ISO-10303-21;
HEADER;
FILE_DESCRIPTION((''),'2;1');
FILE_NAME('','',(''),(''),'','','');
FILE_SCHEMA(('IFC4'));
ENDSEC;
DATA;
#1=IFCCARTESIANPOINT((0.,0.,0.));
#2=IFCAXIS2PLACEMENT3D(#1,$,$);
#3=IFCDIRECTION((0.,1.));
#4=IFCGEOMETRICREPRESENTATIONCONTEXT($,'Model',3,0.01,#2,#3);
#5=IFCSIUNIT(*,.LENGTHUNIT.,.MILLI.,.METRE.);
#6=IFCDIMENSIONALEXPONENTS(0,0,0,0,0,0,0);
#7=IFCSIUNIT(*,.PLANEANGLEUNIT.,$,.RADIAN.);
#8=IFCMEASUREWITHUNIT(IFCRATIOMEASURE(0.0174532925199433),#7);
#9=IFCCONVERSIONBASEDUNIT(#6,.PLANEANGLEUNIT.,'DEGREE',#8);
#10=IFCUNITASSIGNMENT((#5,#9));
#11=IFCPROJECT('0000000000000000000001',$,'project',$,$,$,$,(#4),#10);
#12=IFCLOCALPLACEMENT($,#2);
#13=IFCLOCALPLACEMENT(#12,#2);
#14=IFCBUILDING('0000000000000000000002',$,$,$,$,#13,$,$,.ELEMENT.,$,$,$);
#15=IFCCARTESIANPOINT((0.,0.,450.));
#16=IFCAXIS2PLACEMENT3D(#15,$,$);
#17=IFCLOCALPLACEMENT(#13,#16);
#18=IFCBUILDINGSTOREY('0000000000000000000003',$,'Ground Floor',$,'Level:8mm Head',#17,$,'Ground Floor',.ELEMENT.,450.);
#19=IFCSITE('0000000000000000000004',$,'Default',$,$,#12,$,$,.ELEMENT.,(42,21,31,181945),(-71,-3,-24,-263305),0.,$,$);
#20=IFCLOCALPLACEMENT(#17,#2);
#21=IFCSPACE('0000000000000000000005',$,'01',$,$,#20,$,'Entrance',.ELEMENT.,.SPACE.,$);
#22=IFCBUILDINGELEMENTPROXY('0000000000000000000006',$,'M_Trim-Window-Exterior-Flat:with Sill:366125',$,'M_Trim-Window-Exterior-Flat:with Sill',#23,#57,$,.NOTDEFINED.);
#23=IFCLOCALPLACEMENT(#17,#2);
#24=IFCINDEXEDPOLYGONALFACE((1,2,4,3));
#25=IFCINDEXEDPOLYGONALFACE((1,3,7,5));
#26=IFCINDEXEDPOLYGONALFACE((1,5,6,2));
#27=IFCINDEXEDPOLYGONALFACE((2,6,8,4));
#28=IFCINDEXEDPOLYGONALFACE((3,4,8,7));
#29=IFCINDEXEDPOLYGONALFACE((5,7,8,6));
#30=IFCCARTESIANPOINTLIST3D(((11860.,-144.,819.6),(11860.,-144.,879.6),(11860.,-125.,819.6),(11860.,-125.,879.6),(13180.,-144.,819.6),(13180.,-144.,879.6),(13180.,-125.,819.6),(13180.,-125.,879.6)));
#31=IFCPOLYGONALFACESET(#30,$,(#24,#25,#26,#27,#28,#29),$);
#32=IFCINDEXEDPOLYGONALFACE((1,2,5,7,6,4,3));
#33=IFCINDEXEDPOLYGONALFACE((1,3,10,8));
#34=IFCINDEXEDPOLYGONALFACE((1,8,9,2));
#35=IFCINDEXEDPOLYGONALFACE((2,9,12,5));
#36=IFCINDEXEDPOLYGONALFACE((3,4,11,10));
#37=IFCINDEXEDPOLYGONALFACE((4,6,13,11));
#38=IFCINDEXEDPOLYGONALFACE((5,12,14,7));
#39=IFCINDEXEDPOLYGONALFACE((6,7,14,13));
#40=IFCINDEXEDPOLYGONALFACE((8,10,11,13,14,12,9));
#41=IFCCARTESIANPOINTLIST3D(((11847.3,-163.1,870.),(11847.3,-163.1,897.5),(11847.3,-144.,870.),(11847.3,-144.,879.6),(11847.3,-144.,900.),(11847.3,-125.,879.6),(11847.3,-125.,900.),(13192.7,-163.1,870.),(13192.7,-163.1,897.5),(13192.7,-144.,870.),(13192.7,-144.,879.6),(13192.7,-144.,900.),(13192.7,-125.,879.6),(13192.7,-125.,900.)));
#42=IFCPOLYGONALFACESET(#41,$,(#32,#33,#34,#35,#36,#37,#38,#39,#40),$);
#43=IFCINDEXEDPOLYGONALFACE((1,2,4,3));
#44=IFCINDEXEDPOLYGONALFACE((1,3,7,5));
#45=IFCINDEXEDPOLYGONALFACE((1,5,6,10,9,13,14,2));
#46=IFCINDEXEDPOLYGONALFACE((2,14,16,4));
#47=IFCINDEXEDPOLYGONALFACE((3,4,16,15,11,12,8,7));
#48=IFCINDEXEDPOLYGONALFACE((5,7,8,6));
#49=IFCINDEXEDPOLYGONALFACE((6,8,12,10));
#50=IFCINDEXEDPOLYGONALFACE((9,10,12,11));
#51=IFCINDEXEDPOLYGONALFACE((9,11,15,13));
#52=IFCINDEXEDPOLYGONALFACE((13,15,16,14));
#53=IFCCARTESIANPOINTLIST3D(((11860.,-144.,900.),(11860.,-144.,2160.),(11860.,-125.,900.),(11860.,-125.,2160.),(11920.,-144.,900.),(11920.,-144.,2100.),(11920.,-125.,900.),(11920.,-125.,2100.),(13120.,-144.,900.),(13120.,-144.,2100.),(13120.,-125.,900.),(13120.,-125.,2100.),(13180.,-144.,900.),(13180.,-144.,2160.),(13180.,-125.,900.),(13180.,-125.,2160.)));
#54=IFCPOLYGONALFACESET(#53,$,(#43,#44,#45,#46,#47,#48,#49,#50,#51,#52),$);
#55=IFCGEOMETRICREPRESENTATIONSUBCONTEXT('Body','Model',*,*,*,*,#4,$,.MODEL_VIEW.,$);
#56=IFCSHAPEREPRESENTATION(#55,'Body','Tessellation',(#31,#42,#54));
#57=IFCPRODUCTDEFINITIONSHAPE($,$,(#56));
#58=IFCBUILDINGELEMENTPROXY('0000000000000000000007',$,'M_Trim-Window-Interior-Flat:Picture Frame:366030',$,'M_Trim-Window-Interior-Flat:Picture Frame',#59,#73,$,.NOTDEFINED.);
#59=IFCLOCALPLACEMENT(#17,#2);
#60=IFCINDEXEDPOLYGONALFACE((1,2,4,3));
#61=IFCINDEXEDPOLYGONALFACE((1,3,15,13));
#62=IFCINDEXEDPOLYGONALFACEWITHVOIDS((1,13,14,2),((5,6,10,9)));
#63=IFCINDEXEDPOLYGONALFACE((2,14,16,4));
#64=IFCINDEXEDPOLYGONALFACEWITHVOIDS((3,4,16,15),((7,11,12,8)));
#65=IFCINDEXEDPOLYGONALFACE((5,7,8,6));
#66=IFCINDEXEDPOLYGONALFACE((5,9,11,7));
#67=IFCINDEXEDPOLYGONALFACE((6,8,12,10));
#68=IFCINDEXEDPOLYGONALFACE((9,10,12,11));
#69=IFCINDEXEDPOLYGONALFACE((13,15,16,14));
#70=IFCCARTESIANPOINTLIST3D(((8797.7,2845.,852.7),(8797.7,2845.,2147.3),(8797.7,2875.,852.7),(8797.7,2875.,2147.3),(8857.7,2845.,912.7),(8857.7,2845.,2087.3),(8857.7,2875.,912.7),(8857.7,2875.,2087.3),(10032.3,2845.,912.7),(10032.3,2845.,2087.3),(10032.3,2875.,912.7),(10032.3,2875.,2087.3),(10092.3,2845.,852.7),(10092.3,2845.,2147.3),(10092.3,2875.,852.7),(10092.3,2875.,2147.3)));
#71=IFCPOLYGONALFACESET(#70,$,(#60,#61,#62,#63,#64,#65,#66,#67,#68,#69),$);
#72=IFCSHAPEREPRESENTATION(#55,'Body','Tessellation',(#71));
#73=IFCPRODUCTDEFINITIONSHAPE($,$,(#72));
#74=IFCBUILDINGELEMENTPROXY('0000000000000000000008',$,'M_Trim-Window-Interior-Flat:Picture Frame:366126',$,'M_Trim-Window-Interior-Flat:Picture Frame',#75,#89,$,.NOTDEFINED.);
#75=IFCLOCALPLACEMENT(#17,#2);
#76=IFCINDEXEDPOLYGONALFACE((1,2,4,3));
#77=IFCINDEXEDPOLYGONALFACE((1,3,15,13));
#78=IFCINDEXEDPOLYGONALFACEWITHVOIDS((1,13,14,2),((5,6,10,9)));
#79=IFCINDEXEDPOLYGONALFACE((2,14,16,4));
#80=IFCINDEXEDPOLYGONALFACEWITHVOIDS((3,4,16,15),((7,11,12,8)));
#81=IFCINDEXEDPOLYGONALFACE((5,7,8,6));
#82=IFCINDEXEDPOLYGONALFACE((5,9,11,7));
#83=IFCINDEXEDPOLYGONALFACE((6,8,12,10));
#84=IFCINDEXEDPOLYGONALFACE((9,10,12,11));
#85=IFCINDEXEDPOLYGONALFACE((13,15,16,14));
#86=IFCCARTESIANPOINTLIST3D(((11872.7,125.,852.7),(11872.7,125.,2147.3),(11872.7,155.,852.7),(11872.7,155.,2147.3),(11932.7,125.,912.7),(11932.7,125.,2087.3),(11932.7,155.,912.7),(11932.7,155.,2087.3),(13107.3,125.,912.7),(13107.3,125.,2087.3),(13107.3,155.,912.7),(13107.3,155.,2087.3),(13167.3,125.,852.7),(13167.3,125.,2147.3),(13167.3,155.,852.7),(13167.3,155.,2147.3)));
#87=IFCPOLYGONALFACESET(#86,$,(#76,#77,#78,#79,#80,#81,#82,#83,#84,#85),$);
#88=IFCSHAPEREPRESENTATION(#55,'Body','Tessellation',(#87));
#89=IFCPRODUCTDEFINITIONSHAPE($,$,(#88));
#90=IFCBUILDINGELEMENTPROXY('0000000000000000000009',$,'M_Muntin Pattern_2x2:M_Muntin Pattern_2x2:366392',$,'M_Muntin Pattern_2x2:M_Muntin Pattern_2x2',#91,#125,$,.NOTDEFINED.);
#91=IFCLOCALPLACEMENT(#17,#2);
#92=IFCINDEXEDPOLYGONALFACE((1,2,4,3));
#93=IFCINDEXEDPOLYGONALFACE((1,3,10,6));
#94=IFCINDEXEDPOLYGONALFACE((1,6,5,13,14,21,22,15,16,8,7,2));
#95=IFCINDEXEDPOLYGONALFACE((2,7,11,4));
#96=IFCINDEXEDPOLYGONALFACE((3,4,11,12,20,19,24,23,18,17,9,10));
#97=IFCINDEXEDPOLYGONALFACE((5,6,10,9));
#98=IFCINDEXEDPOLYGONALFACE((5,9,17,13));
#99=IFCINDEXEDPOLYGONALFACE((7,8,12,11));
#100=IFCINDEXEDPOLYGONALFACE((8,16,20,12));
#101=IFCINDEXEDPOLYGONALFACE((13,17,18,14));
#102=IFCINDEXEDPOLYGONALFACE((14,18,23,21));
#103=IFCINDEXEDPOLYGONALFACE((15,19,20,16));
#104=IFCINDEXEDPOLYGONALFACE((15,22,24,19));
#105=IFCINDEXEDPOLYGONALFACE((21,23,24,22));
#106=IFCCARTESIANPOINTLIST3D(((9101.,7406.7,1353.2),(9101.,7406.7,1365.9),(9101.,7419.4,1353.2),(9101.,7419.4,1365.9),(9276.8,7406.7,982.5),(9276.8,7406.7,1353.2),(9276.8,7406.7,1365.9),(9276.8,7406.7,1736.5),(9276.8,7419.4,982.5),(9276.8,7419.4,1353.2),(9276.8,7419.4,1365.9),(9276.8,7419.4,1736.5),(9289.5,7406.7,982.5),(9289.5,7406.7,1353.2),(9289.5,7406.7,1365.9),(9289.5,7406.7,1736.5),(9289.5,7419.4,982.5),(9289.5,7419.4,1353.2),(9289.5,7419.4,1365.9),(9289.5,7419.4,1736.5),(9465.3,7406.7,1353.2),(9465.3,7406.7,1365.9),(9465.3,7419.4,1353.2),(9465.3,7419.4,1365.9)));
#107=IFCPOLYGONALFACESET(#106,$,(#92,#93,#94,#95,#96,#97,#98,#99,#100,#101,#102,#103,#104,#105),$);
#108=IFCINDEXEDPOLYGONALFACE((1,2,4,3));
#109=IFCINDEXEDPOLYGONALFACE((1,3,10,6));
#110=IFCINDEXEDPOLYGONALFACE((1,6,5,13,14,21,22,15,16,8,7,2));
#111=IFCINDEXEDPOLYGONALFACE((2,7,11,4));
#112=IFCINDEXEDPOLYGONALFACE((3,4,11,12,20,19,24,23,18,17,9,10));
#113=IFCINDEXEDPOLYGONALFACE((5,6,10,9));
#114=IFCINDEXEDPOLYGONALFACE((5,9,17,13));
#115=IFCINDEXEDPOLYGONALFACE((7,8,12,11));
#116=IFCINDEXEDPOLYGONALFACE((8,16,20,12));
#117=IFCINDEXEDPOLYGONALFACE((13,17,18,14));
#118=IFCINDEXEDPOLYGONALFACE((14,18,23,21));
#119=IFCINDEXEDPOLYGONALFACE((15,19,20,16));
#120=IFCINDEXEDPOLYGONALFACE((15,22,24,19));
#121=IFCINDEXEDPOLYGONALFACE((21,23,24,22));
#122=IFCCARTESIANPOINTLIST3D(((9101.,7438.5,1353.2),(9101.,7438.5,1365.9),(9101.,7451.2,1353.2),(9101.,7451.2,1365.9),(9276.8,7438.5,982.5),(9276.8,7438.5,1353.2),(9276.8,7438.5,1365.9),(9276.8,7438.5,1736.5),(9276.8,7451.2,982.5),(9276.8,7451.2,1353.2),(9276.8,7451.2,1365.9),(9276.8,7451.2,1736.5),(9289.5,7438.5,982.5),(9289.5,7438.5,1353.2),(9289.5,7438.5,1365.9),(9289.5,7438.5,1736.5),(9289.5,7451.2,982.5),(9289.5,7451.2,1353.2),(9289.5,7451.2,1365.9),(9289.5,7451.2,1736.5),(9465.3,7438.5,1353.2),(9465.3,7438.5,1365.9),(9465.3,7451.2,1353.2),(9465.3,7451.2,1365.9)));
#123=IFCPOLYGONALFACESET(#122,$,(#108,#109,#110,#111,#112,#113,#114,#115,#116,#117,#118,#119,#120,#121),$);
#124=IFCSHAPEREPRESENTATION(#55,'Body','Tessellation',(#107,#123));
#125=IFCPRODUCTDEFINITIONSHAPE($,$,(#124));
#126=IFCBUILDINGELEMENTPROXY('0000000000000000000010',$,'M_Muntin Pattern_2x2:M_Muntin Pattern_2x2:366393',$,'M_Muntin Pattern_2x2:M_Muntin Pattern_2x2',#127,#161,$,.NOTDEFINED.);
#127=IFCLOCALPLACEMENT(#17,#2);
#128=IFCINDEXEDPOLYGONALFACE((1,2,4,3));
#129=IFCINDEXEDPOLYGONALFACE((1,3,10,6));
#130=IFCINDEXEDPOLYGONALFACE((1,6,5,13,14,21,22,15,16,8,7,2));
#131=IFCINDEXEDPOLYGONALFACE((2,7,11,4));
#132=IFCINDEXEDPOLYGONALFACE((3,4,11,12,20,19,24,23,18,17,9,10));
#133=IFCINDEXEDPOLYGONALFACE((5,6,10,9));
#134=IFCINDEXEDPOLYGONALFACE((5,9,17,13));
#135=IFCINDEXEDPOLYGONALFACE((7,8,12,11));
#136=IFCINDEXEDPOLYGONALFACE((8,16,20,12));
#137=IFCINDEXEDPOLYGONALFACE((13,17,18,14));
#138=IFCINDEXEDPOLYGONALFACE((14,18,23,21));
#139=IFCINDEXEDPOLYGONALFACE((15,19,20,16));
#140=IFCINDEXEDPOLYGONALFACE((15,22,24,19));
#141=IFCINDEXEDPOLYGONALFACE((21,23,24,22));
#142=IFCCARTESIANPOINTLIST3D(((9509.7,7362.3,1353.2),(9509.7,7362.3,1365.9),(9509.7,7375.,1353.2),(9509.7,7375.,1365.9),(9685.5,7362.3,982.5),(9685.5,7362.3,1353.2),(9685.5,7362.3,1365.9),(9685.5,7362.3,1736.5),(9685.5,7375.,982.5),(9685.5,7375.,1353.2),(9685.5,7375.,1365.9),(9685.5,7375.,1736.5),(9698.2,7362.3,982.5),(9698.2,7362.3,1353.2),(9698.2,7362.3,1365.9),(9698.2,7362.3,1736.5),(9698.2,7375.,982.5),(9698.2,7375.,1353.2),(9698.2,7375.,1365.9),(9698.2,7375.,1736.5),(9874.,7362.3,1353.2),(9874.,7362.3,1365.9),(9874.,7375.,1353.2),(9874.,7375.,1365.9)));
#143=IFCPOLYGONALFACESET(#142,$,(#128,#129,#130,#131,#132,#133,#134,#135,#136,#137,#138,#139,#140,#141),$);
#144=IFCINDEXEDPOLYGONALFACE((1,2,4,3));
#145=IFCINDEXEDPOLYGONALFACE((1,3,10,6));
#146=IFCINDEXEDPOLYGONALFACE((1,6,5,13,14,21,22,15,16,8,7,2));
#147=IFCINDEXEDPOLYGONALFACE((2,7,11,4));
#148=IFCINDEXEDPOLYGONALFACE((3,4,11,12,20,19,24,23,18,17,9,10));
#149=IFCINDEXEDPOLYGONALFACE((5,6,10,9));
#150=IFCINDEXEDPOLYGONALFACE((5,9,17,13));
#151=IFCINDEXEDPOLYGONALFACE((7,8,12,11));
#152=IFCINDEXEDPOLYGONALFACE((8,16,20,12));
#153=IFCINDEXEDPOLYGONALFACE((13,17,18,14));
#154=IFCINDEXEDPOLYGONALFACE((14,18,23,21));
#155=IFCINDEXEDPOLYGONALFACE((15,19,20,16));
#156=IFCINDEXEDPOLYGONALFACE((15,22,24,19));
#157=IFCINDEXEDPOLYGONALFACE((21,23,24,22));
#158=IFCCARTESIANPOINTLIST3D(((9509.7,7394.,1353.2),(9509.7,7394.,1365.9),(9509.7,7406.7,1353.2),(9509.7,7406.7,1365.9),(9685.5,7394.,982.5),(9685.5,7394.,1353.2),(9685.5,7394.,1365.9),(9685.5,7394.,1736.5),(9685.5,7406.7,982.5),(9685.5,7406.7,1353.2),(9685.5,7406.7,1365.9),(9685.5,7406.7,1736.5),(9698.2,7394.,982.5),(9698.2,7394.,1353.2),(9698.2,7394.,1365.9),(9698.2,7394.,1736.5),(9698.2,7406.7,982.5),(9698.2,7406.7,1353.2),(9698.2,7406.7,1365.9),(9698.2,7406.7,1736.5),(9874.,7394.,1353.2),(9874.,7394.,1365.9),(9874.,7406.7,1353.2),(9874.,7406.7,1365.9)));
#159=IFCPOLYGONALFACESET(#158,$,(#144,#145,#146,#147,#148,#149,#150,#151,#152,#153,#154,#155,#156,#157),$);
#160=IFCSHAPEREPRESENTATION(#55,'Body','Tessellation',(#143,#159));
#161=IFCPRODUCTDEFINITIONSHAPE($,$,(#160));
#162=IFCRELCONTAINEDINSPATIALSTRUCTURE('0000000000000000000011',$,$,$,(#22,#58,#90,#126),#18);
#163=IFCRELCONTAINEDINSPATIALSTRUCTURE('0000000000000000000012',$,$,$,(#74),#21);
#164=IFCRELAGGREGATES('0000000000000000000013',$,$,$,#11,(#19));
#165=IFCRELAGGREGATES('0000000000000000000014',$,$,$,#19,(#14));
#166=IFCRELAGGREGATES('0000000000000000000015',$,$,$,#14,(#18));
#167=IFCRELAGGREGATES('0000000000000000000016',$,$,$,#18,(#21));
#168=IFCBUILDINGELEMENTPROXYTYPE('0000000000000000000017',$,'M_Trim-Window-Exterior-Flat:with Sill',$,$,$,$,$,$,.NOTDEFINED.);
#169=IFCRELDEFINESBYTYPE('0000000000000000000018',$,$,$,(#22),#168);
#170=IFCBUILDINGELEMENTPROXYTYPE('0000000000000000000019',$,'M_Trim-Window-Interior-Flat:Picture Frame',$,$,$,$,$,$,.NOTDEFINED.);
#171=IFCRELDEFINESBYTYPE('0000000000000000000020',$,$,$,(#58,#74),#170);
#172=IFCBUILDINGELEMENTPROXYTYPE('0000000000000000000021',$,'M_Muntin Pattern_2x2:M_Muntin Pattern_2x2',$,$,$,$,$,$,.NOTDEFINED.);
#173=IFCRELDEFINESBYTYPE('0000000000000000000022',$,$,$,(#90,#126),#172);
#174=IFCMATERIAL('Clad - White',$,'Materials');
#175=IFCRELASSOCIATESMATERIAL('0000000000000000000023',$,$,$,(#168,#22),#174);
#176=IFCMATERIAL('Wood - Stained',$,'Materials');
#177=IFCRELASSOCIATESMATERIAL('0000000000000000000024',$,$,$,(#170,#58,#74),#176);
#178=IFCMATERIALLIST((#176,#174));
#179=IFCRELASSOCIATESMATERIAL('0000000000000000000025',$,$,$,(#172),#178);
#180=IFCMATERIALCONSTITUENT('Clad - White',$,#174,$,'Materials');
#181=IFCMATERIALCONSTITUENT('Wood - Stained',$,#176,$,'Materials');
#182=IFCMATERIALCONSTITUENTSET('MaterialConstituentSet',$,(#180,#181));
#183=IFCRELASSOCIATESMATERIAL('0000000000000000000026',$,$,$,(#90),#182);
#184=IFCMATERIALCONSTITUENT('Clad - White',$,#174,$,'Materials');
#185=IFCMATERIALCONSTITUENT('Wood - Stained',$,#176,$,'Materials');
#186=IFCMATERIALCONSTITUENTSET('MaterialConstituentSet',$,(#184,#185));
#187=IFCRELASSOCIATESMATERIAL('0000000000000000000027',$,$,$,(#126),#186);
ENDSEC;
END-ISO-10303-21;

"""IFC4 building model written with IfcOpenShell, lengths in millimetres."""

from ifc_helpers import new_model, entity, si_unit, converted_unit, direction, frame, frame_2d, origin, place, context, subcontext, project, spatial, polyline, rectangle, outline, extrude, source, transform, mapped, material, material_list, constituent, constituent_set, type_object, type_shapes, element, save


model = new_model("IFC4")

# Units and contexts
model_context = context("Model", 3, precision=0.01, world=origin(), true_north=direction((0.0, 1.0)))
body_context = subcontext(model_context, "Body", "Model", "MODEL_VIEW")
ifc_project = project(units=[si_unit("LENGTHUNIT", "METRE", prefix="MILLI"), converted_unit("PLANEANGLEUNIT", "DEGREE", entity("IfcRatioMeasure", 0.0174532925199433), si_unit("PLANEANGLEUNIT", "RADIAN"), dimensions=[0, 0, 0, 0, 0, 0, 0])], contexts=[model_context])

# Site, building, storey
site_placement = place(None, origin())
site = spatial("IfcSite", under=ifc_project, at=site_placement, Name="Default", CompositionType="ELEMENT", RefLatitude=(42, 21, 31, 181945), RefLongitude=(-71, -3, -24, -263305), RefElevation=0.0)
building_placement = place(site_placement, origin())
building = spatial("IfcBuilding", under=site, at=building_placement, CompositionType="ELEMENT")
storey_placement = place(building_placement, frame((0.0, 0.0, 450.0)))
storey = spatial("IfcBuildingStorey", under=building, at=storey_placement, Name="Ground Floor", ObjectType="Level:8mm Head", LongName="Ground Floor", CompositionType="ELEMENT", Elevation=450.0)

# Shared definitions
ifc_material_1 = material(Name="Clad - White", Category="Materials")
ifc_material_2 = material(Name="Wood - Stained", Category="Materials")

# Building element proxies
building_element_proxy_type_1 = type_object("IfcBuildingElementProxyType", Name="M_Trim-Window-Exterior-Flat:with Sill", PredefinedType="NOTDEFINED", material=ifc_material_1)
shared_shape_1 = source(origin(), body_context, "Body", "SweptSolid", [
    extrude(rectangle(XDim=1320.0, YDim=60.0, at=frame_2d((0.0, 0.0), x_axis=(1.0, 0.0))), frame((0.0, -1250.4, 0.0), z_axis=(0.0, 0.0, 1.0), x_axis=(-1.0, 0.0, 0.0)), (0.0, 0.0, 1.0), 19.1),
    extrude(outline(polyline([(-19.0, -15.2), (0.0, -15.2), (0.0, -5.7), (19.0, -5.7), (19.0, 14.8), (0.0, 14.8), (-19.0, 12.3), (-19.0, -15.2)])), frame((-672.7, -1214.8, 19.0), z_axis=(1.0, 0.0, 0.0), x_axis=(0.0, 0.0, -1.0)), (0.0, 0.0, 1.0), 1345.4),
    extrude(outline(polyline([(-645.0, -660.0), (615.0, -660.0), (615.0, -600.0), (-585.0, -600.0), (-585.0, 600.0), (615.0, 600.0), (615.0, 660.0), (-645.0, 660.0), (-645.0, -660.0)])), frame((0.0, -585.0, 0.0), z_axis=(0.0, 0.0, 1.0), x_axis=(0.0, -1.0, 0.0)), (0.0, 0.0, 1.0), 19.1),
])
type_shapes(building_element_proxy_type_1, [shared_shape_1])
proxy_1_placement = place(storey_placement, frame((12520.0, -125.0, 2100.0), z_axis=(0.0, -1.0, 0.0), x_axis=(1.0, 0.0, 0.0)))
element("IfcBuildingElementProxy", 1, at=proxy_1_placement, inside=storey, type_object=building_element_proxy_type_1, material=ifc_material_1, Name="M_Trim-Window-Exterior-Flat:with Sill:366125", ObjectType="M_Trim-Window-Exterior-Flat:with Sill", PredefinedType="NOTDEFINED", context=body_context, shape_type="MappedRepresentation", body=[
    mapped(shared_shape_1, transform((0.0, 0.0, 0.0), scale=1.0)),
])
building_element_proxy_type_2 = type_object("IfcBuildingElementProxyType", Name="M_Trim-Window-Interior-Flat:Picture Frame", PredefinedType="NOTDEFINED", material=ifc_material_2)
shared_shape_2 = source(origin(), body_context, "Body", "SweptSolid", [
    extrude(outline(polyline([(-647.3, -647.3), (647.3, -647.3), (647.3, 647.3), (-647.3, 647.3), (-647.3, -647.3)]), holes=[polyline([(-587.3, -587.3), (-587.3, 587.3), (587.3, 587.3), (587.3, -587.3), (-587.3, -587.3)])]), frame((0.0, -600.0, 0.0), z_axis=(0.0, 0.0, 1.0), x_axis=(-1.0, 0.0, 0.0)), (0.0, 0.0, 1.0), 30.0),
])
type_shapes(building_element_proxy_type_2, [shared_shape_2])
proxy_2_placement = place(storey_placement, frame((9445.0, 2875.0, 2100.0), z_axis=(0.0, -1.0, 0.0), x_axis=(1.0, 0.0, 0.0)))
element("IfcBuildingElementProxy", 2, at=proxy_2_placement, inside=storey, type_object=building_element_proxy_type_2, material=ifc_material_2, Name="M_Trim-Window-Interior-Flat:Picture Frame:366030", ObjectType="M_Trim-Window-Interior-Flat:Picture Frame", PredefinedType="NOTDEFINED", context=body_context, shape_type="MappedRepresentation", body=[
    mapped(shared_shape_2, transform((0.0, 0.0, 0.0), scale=1.0)),
])

# Shared definitions
space_1_placement = place(storey_placement, origin())
space_1 = spatial("IfcSpace", under=storey, at=space_1_placement, Name="01", LongName="Entrance", CompositionType="ELEMENT", PredefinedType="SPACE")

# Building element proxies
proxy_3_placement = place(space_1_placement, frame((12520.0, 125.0, 2100.0), z_axis=(0.0, 1.0, 0.0), x_axis=(-1.0, 0.0, 0.0)))
element("IfcBuildingElementProxy", 3, at=proxy_3_placement, inside=space_1, type_object=building_element_proxy_type_2, material=ifc_material_2, Name="M_Trim-Window-Interior-Flat:Picture Frame:366126", ObjectType="M_Trim-Window-Interior-Flat:Picture Frame", PredefinedType="NOTDEFINED", context=body_context, shape_type="MappedRepresentation", body=[
    mapped(shared_shape_2, transform((0.0, 0.0, 0.0), scale=1.0)),
])
ifc_constituent_1 = constituent(ifc_material_1, Name="Clad - White", Category="Materials")
ifc_constituent_2 = constituent(ifc_material_2, Name="Wood - Stained", Category="Materials")
ifc_constituent_set_1 = constituent_set(constituents=[ifc_constituent_1, ifc_constituent_2], Name="MaterialConstituentSet")
ifc_material_list_1 = material_list([ifc_material_2, ifc_material_1])
building_element_proxy_type_3 = type_object("IfcBuildingElementProxyType", Name="M_Muntin Pattern_2x2:M_Muntin Pattern_2x2", PredefinedType="NOTDEFINED", material=ifc_material_list_1)
shared_shape_3 = source(origin(), body_context, "Body", "SweptSolid", [
    extrude(outline(polyline([(6.4, -6.4), (377.0, -6.4), (377.0, 6.3), (6.4, 6.3), (6.4, 182.1), (-6.3, 182.1), (-6.3, 6.3), (-377.0, 6.3), (-377.0, -6.4), (-6.3, -6.4), (-6.3, -182.1), (6.4, -182.1), (6.4, -6.4)])), frame((0.0, 9.5, 377.0), z_axis=(0.0, 1.0, 0.0), x_axis=(0.0, 0.0, 1.0)), (0.0, 0.0, 1.0), 12.7),
    extrude(outline(polyline([(6.4, -6.4), (377.0, -6.4), (377.0, 6.3), (6.4, 6.3), (6.4, 182.1), (-6.3, 182.1), (-6.3, 6.3), (-377.0, 6.3), (-377.0, -6.4), (-6.3, -6.4), (-6.3, -182.1), (6.4, -182.1), (6.4, -6.4)])), frame((0.0, -22.2, 377.0), z_axis=(0.0, 1.0, 0.0), x_axis=(0.0, 0.0, 1.0)), (0.0, 0.0, 1.0), 12.7),
])
type_shapes(building_element_proxy_type_3, [shared_shape_3])
proxy_4_placement = place(storey_placement, frame((9283.1, 7429.0, 982.5), z_axis=(0.0, 0.0, 1.0), x_axis=(-1.0, 0.0, 0.0)))
element("IfcBuildingElementProxy", 4, at=proxy_4_placement, inside=storey, type_object=building_element_proxy_type_3, material=ifc_constituent_set_1, Name="M_Muntin Pattern_2x2:M_Muntin Pattern_2x2:366392", ObjectType="M_Muntin Pattern_2x2:M_Muntin Pattern_2x2", PredefinedType="NOTDEFINED", context=body_context, shape_type="MappedRepresentation", body=[
    mapped(shared_shape_3, transform((0.0, 0.0, 0.0), scale=1.0)),
])
ifc_constituent_3 = constituent(ifc_material_1, Name="Clad - White", Category="Materials")
ifc_constituent_4 = constituent(ifc_material_2, Name="Wood - Stained", Category="Materials")
ifc_constituent_set_2 = constituent_set(constituents=[ifc_constituent_3, ifc_constituent_4], Name="MaterialConstituentSet")
proxy_5_placement = place(storey_placement, frame((9691.9, 7384.5, 982.5), z_axis=(0.0, 0.0, 1.0), x_axis=(-1.0, 0.0, 0.0)))
element("IfcBuildingElementProxy", 5, at=proxy_5_placement, inside=storey, type_object=building_element_proxy_type_3, material=ifc_constituent_set_2, Name="M_Muntin Pattern_2x2:M_Muntin Pattern_2x2:366393", ObjectType="M_Muntin Pattern_2x2:M_Muntin Pattern_2x2", PredefinedType="NOTDEFINED", context=body_context, shape_type="MappedRepresentation", body=[
    mapped(shared_shape_3, transform((0.0, 0.0, 0.0), scale=1.0)),
])

save(model, "model.ifc")
